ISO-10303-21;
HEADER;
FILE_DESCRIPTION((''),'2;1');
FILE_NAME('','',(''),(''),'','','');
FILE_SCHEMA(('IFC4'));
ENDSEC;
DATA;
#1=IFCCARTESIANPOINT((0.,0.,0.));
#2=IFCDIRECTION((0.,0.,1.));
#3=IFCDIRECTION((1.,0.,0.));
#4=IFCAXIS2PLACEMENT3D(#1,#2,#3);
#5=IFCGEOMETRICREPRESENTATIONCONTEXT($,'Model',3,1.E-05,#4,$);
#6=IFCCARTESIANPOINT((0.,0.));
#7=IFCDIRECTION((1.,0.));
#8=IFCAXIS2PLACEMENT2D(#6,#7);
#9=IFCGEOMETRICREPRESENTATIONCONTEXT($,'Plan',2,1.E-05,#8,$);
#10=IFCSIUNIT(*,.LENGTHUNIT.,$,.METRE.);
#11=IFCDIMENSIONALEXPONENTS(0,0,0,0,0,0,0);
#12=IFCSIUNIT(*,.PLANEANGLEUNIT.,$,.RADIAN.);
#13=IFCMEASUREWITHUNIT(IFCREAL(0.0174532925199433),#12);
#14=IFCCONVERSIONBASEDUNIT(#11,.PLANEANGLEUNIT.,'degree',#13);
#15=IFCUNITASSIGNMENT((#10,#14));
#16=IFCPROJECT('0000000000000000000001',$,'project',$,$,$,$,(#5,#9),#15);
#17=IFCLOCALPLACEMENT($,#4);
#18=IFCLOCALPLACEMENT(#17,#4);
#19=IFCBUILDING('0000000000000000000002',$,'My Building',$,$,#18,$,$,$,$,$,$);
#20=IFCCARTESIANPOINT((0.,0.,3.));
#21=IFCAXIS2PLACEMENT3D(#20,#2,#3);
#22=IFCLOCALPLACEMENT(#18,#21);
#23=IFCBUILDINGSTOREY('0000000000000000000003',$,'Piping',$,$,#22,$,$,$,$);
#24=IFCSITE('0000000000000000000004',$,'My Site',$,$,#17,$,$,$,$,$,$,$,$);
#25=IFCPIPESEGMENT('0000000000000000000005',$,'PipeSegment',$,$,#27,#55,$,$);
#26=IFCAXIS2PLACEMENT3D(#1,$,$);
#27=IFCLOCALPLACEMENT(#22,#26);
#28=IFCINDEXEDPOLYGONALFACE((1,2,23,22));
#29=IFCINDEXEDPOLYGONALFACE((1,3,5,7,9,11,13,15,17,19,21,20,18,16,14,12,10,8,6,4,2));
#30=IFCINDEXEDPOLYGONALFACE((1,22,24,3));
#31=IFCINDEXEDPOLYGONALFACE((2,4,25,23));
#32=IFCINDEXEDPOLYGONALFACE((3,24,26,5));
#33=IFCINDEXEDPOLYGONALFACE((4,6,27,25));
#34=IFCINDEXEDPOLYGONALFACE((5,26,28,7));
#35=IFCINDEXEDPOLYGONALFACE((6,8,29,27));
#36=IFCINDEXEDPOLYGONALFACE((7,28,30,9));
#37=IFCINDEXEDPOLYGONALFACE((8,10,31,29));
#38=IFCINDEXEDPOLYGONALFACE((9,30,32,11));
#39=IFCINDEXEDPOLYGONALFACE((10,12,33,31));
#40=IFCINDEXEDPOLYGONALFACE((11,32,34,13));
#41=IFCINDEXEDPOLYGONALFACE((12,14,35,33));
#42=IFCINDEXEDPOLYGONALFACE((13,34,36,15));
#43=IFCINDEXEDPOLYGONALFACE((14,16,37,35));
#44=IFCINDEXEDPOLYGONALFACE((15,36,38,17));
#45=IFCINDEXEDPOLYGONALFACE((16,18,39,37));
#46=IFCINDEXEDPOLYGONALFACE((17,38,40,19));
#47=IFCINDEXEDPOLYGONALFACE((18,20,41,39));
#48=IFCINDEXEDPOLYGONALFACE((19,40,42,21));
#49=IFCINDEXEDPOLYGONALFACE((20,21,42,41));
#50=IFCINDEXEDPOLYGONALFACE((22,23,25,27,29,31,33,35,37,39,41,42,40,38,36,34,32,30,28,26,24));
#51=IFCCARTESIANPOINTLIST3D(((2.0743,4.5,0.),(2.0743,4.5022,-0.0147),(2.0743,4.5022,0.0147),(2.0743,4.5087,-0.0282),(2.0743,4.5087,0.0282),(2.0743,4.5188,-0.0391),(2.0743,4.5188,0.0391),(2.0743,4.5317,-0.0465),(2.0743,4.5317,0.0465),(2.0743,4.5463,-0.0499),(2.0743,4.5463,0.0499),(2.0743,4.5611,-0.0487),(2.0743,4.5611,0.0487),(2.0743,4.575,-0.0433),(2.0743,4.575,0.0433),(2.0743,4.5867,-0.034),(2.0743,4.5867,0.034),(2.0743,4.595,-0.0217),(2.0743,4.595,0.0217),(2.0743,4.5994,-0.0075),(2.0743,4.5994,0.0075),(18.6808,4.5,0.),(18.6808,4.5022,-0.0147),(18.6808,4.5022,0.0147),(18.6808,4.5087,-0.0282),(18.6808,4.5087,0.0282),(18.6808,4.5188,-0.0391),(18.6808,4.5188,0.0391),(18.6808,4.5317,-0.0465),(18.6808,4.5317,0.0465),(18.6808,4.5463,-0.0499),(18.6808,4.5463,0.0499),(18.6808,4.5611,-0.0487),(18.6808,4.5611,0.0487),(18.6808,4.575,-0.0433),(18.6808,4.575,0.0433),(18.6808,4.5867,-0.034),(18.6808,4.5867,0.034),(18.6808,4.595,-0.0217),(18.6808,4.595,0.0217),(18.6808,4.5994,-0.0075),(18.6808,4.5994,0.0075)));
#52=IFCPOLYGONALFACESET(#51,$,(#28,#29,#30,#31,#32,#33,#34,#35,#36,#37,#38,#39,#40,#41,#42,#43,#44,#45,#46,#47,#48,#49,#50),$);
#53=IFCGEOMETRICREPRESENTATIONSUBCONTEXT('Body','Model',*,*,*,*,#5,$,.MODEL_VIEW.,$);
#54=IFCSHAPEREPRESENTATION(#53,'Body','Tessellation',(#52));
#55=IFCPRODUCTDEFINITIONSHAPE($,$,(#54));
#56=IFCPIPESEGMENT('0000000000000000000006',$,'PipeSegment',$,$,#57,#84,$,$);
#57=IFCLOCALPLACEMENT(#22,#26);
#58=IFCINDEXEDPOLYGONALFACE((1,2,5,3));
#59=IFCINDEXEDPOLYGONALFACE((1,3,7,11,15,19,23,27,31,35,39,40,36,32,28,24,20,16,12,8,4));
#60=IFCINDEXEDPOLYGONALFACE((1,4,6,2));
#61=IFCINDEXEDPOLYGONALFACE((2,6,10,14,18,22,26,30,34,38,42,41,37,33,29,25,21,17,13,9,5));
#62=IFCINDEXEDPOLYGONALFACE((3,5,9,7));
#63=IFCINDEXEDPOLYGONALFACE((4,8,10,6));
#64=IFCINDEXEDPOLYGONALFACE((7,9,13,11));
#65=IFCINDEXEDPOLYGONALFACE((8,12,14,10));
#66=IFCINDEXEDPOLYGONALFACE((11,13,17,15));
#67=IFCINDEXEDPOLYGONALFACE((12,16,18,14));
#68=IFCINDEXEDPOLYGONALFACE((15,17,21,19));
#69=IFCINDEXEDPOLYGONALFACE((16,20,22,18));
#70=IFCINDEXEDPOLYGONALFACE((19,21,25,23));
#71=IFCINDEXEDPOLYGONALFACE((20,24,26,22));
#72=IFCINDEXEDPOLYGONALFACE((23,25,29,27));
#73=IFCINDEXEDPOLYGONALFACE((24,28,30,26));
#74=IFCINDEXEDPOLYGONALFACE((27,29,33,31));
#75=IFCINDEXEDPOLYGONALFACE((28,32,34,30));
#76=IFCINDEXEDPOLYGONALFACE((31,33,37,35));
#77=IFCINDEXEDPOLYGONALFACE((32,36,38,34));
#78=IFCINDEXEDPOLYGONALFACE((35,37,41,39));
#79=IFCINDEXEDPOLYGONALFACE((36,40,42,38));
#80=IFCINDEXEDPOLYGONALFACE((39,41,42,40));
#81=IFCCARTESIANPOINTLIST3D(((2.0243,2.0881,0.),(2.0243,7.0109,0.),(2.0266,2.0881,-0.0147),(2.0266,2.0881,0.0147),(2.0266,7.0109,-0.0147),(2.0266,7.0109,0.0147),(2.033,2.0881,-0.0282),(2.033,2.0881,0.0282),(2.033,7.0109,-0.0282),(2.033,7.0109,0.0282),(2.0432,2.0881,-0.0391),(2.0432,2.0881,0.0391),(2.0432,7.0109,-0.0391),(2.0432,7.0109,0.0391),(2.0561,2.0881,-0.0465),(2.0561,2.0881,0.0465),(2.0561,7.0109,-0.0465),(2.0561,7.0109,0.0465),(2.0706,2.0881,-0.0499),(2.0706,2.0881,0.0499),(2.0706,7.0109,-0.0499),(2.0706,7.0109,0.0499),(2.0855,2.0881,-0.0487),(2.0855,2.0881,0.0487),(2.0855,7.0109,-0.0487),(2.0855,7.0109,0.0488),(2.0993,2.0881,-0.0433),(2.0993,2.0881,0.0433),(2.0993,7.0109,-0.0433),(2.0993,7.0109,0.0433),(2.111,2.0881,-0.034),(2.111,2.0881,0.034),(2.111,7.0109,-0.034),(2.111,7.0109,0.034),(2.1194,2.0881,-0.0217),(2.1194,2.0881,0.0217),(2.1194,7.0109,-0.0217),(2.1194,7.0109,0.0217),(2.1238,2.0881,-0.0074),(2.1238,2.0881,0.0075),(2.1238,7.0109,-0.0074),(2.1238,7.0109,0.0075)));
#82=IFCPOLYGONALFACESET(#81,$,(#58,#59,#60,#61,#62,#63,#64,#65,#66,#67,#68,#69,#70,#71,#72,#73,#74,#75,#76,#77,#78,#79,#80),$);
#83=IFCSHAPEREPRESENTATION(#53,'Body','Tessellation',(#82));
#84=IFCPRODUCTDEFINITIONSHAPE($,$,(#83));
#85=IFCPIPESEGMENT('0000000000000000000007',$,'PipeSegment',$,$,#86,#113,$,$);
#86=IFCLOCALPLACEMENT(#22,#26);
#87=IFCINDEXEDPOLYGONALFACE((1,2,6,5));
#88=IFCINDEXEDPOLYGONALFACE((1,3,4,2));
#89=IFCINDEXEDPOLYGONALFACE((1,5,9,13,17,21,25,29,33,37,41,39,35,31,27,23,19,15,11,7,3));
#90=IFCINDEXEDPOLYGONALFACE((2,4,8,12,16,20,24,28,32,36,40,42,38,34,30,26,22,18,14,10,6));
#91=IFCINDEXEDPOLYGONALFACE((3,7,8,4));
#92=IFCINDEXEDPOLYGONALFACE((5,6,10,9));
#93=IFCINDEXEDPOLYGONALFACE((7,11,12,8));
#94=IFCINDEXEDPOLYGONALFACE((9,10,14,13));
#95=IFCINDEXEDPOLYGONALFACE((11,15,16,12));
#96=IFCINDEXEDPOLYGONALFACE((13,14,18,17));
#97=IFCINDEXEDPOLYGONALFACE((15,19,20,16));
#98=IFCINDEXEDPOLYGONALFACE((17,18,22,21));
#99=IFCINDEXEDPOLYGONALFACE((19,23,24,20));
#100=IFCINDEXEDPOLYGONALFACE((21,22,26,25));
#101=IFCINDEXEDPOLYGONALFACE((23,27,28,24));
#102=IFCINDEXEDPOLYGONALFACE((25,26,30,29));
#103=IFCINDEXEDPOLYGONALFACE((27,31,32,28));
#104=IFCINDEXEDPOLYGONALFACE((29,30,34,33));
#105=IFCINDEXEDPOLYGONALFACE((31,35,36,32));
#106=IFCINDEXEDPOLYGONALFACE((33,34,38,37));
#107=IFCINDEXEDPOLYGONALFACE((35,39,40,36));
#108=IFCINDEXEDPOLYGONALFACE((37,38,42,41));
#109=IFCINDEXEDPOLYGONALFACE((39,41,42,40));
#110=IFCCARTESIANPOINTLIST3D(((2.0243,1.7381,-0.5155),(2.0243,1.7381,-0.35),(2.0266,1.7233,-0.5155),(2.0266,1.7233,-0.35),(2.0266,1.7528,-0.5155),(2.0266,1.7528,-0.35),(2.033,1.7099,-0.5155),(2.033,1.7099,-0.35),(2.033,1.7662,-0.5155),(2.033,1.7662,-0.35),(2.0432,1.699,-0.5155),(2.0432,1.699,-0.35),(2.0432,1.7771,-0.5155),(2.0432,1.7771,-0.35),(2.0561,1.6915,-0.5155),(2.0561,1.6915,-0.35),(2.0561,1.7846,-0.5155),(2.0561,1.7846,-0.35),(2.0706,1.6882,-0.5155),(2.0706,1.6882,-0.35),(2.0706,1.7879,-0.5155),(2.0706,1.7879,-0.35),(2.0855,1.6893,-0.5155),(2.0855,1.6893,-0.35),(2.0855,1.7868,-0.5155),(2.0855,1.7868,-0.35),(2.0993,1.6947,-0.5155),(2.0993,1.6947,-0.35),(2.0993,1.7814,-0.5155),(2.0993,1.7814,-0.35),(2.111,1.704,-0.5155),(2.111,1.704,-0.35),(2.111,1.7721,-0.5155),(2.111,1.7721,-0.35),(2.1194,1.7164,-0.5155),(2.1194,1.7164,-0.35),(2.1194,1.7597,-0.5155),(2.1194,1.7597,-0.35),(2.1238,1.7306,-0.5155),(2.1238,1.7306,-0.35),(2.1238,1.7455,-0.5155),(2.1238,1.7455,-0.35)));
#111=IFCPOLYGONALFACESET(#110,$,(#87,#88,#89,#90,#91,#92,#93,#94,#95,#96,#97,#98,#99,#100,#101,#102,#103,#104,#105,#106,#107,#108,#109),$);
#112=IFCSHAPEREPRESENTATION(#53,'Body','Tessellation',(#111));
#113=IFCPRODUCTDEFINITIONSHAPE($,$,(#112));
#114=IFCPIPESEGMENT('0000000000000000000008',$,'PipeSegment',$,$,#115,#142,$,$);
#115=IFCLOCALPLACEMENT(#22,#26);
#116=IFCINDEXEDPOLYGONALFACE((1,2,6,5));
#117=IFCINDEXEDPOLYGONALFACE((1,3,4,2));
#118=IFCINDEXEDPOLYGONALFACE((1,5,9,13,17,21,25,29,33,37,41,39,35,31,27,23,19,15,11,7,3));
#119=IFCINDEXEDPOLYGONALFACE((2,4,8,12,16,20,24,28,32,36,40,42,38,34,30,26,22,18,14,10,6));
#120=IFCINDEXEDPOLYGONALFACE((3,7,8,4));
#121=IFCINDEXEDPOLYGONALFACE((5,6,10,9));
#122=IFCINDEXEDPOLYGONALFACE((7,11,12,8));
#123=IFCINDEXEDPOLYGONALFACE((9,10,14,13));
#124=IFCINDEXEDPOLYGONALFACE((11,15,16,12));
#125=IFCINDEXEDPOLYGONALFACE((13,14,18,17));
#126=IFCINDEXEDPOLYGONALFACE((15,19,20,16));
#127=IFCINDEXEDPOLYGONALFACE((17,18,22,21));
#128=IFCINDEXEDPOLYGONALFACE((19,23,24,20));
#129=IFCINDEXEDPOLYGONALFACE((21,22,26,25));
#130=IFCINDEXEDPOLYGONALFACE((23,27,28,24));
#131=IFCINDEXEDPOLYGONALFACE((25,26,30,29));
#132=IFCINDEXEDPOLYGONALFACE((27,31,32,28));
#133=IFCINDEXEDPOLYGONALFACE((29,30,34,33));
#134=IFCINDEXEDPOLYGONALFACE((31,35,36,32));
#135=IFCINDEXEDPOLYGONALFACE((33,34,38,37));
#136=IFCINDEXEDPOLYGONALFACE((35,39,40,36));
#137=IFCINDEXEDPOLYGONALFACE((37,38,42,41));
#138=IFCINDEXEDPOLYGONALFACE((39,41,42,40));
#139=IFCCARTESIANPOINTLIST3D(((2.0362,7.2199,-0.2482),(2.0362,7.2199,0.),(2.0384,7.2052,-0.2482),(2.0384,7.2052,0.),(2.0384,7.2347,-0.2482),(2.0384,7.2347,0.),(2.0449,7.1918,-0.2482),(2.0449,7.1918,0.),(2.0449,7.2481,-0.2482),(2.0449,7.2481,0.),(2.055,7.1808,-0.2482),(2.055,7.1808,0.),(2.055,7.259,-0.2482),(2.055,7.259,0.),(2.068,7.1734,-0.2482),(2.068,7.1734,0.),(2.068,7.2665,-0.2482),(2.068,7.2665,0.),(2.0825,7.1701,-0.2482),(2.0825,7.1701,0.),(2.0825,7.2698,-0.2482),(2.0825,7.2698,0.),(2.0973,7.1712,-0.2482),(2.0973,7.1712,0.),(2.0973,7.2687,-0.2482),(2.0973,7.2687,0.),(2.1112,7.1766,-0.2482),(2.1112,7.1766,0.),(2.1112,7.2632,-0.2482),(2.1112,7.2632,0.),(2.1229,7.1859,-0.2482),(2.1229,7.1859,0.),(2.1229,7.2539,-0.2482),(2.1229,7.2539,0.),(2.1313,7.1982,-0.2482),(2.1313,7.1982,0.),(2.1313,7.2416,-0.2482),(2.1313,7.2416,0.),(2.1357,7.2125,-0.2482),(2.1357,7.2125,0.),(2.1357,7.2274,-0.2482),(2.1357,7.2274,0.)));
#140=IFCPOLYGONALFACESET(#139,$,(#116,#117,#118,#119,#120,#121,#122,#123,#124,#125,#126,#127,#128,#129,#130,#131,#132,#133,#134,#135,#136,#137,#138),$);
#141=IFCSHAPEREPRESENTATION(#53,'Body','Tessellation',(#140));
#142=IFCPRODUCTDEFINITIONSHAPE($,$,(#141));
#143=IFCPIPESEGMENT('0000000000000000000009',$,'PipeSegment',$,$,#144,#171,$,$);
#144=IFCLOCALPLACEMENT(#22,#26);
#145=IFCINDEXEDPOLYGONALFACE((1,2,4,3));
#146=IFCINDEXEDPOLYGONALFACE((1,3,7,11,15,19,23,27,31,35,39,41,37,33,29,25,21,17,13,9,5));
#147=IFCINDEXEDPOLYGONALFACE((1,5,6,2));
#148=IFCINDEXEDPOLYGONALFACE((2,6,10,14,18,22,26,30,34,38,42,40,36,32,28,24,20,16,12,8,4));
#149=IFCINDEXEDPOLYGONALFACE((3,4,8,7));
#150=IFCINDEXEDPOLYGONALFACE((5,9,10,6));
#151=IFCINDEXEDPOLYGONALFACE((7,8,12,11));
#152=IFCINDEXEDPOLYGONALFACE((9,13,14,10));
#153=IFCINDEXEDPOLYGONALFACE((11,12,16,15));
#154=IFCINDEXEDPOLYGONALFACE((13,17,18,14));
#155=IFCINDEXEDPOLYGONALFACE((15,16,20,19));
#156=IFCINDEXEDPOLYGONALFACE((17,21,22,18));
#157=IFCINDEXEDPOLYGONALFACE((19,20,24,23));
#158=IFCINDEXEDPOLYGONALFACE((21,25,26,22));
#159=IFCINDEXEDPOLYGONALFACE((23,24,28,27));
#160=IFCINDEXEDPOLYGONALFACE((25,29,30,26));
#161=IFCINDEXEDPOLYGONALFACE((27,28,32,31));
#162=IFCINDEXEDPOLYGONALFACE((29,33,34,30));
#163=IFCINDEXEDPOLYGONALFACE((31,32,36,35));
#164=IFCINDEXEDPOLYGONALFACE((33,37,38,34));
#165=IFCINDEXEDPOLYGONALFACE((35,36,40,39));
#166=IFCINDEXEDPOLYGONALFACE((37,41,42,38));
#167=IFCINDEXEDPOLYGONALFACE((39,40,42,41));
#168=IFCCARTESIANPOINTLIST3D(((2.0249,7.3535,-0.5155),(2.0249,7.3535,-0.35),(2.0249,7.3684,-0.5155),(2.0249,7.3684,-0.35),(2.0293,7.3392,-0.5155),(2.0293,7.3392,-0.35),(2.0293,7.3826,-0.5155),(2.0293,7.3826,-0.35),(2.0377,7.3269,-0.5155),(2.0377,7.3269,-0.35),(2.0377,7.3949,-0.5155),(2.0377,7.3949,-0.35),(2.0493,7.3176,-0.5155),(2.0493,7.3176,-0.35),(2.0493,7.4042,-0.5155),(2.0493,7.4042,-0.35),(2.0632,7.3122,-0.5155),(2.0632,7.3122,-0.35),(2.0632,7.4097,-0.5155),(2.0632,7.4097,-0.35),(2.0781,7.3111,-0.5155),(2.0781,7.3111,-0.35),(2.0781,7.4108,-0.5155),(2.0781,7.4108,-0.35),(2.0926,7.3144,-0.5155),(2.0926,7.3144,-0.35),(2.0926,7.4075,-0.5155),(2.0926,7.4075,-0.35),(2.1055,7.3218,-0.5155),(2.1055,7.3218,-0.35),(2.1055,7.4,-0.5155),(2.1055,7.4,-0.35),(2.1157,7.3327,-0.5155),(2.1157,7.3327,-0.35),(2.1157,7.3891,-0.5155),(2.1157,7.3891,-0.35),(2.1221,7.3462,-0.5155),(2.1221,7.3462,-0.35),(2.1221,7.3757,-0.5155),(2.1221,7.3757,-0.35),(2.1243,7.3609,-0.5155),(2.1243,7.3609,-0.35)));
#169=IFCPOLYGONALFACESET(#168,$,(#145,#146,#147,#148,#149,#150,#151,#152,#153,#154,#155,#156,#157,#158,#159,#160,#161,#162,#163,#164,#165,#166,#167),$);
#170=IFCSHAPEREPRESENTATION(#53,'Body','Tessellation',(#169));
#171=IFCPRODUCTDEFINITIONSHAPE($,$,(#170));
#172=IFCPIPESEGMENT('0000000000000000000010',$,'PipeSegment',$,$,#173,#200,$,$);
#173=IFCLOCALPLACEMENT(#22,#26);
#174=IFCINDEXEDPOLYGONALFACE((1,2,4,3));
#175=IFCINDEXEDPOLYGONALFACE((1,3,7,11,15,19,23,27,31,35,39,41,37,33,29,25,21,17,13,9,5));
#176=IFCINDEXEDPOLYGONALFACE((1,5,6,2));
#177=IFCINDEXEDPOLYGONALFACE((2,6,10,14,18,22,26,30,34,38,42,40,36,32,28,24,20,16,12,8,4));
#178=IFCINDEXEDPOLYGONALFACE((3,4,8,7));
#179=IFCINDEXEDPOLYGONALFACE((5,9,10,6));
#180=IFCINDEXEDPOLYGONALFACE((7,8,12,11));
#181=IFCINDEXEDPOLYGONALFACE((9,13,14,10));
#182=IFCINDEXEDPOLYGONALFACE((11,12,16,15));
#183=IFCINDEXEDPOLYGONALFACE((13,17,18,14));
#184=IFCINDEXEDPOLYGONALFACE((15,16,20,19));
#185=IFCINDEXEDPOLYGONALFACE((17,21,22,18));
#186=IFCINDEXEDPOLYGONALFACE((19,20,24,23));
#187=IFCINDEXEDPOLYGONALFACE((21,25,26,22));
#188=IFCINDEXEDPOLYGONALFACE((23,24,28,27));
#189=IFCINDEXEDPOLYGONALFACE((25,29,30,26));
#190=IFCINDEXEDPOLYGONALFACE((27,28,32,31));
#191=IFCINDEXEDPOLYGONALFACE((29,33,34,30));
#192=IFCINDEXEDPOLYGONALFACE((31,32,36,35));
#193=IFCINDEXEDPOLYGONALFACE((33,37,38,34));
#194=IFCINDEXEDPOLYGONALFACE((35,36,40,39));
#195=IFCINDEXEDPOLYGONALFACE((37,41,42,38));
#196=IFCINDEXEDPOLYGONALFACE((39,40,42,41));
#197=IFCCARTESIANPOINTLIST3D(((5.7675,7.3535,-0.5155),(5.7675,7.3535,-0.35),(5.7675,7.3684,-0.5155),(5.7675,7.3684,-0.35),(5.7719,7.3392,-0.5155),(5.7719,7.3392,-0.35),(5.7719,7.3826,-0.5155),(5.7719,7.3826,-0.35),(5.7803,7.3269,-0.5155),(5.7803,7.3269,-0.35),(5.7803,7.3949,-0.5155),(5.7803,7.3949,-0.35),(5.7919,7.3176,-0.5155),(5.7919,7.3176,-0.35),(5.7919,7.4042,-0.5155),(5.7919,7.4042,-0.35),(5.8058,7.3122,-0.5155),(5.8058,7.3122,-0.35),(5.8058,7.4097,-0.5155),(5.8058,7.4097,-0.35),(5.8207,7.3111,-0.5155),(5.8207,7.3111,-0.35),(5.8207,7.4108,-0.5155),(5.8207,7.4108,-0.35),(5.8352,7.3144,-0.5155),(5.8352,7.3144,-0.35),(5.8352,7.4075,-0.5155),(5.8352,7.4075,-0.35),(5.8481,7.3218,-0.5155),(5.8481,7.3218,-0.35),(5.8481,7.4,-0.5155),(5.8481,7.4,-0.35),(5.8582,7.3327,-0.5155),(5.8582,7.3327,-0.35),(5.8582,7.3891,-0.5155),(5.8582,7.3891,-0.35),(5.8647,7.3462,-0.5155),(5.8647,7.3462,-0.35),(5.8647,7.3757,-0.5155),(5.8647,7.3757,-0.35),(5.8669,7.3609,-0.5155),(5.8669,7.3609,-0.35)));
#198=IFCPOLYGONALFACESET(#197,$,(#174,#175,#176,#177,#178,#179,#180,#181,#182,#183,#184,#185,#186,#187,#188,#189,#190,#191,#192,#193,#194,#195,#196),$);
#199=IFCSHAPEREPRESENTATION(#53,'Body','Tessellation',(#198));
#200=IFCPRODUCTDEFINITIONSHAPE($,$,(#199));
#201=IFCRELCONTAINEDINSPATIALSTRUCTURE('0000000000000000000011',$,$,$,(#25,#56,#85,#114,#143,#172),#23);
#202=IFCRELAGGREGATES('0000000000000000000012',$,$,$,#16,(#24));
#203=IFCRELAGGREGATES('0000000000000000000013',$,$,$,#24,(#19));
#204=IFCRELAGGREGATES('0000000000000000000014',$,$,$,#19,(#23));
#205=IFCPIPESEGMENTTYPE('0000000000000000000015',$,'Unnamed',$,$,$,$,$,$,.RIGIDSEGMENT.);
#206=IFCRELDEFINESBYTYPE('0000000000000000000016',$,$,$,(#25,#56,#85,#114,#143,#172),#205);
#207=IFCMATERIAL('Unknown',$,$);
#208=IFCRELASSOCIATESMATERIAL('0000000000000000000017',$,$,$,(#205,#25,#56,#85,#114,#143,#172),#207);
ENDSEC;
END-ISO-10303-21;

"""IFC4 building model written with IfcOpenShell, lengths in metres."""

from ifc_helpers import new_model, entity, si_unit, converted_unit, frame, origin_with_axes, origin_2d_with_axis, place, context, subcontext, project, spatial, circle, extrude, material, material_profile, profile_set, profile_usage, type_object, element, save


model = new_model("IFC4")

# Units and contexts
model_context = context("Model", 3, precision=1e-05, world=origin_with_axes())
plan_context = context("Plan", 2, precision=1e-05, world=origin_2d_with_axis())
body_context = subcontext(model_context, "Body", "Model", "MODEL_VIEW")
ifc_project = project(units=[si_unit("LENGTHUNIT", "METRE"), converted_unit("PLANEANGLEUNIT", "degree", entity("IfcReal", 0.0174532925199433), si_unit("PLANEANGLEUNIT", "RADIAN"), dimensions=[0, 0, 0, 0, 0, 0, 0])], contexts=[model_context, plan_context])

# Site, building, storey
site_placement = place(None, origin_with_axes())
site = spatial("IfcSite", under=ifc_project, at=site_placement, Name="My Site")
building_placement = place(site_placement, origin_with_axes())
building = spatial("IfcBuilding", under=site, at=building_placement, Name="My Building")
storey_placement = place(building_placement, frame((0.0, 0.0, 3.0), z_axis=(0.0, 0.0, 1.0), x_axis=(1.0, 0.0, 0.0)))
storey = spatial("IfcBuildingStorey", under=building, at=storey_placement, Name="Piping")

# Pipe segments
ifc_material = material(Name="Unknown")
ifc_material_profile = material_profile(ifc_material, circle(Radius=0.05))
ifc_profile_set = profile_set([ifc_material_profile])
ifc_profile_usage_1 = profile_usage(ifc_profile_set, cardinal=5)
pipe_segment_type = type_object("IfcPipeSegmentType", Name="Unnamed", PredefinedType="RIGIDSEGMENT", material=ifc_profile_set)
pipe_segment_1_placement = place(storey_placement, frame((18.6808, 4.55, 0.0), z_axis=(-1.0, 0.0, 0.0), x_axis=(0.0, -1.0, 0.0)))
element("IfcPipeSegment", 1, at=pipe_segment_1_placement, inside=storey, type_object=pipe_segment_type, material=ifc_profile_usage_1, Name="PipeSegment", context=body_context, shape_type="SweptSolid", body=[
    extrude(circle(Radius=0.05), origin_with_axes(), (0.0, 0.0, 1.0), 16.6065),
])
ifc_profile_usage_2 = profile_usage(ifc_profile_set, cardinal=5)
pipe_segment_2_placement = place(storey_placement, frame((2.0743, 2.0881, 0.0), z_axis=(0.0, 1.0, 0.0), x_axis=(-1.0, 0.0, 0.0)))
element("IfcPipeSegment", 2, at=pipe_segment_2_placement, inside=storey, type_object=pipe_segment_type, material=ifc_profile_usage_2, Name="PipeSegment", context=body_context, shape_type="SweptSolid", body=[
    extrude(circle(Radius=0.05), origin_with_axes(), (0.0, 0.0, 1.0), 4.9229),
])
ifc_profile_usage_3 = profile_usage(ifc_profile_set, cardinal=5)
pipe_segment_3_placement = place(storey_placement, frame((2.0743, 1.7381, -0.35), z_axis=(0.0, 0.0, -1.0), x_axis=(-1.0, 0.0, 0.0)))
element("IfcPipeSegment", 3, at=pipe_segment_3_placement, inside=storey, type_object=pipe_segment_type, material=ifc_profile_usage_3, Name="PipeSegment", context=body_context, shape_type="SweptSolid", body=[
    extrude(circle(Radius=0.05), origin_with_axes(), (0.0, 0.0, 1.0), 0.1655),
])
ifc_profile_usage_4 = profile_usage(ifc_profile_set, cardinal=5)
pipe_segment_4_placement = place(storey_placement, frame((2.0862, 7.2199, 0.0), z_axis=(0.0, 0.0, -1.0), x_axis=(-1.0, 0.0, 0.0)))
element("IfcPipeSegment", 4, at=pipe_segment_4_placement, inside=storey, type_object=pipe_segment_type, material=ifc_profile_usage_4, Name="PipeSegment", context=body_context, shape_type="SweptSolid", body=[
    extrude(circle(Radius=0.05), origin_with_axes(), (0.0, 0.0, 1.0), 0.2482),
])
ifc_profile_usage_5 = profile_usage(ifc_profile_set, cardinal=5)
pipe_segment_5_placement = place(storey_placement, frame((2.0743, 7.3609, -0.35), z_axis=(0.0, 0.0, -1.0), x_axis=(1.0, 0.0, 0.0)))
element("IfcPipeSegment", 5, at=pipe_segment_5_placement, inside=storey, type_object=pipe_segment_type, material=ifc_profile_usage_5, Name="PipeSegment", context=body_context, shape_type="SweptSolid", body=[
    extrude(circle(Radius=0.05), origin_with_axes(), (0.0, 0.0, 1.0), 0.1655),
])
ifc_profile_usage_6 = profile_usage(ifc_profile_set, cardinal=5)
pipe_segment_6_placement = place(storey_placement, frame((5.8169, 7.3609, -0.35), z_axis=(0.0, 0.0, -1.0), x_axis=(1.0, 0.0, 0.0)))
element("IfcPipeSegment", 6, at=pipe_segment_6_placement, inside=storey, type_object=pipe_segment_type, material=ifc_profile_usage_6, Name="PipeSegment", context=body_context, shape_type="SweptSolid", body=[
    extrude(circle(Radius=0.05), origin_with_axes(), (0.0, 0.0, 1.0), 0.1655),
])

save(model, "model.ifc")
